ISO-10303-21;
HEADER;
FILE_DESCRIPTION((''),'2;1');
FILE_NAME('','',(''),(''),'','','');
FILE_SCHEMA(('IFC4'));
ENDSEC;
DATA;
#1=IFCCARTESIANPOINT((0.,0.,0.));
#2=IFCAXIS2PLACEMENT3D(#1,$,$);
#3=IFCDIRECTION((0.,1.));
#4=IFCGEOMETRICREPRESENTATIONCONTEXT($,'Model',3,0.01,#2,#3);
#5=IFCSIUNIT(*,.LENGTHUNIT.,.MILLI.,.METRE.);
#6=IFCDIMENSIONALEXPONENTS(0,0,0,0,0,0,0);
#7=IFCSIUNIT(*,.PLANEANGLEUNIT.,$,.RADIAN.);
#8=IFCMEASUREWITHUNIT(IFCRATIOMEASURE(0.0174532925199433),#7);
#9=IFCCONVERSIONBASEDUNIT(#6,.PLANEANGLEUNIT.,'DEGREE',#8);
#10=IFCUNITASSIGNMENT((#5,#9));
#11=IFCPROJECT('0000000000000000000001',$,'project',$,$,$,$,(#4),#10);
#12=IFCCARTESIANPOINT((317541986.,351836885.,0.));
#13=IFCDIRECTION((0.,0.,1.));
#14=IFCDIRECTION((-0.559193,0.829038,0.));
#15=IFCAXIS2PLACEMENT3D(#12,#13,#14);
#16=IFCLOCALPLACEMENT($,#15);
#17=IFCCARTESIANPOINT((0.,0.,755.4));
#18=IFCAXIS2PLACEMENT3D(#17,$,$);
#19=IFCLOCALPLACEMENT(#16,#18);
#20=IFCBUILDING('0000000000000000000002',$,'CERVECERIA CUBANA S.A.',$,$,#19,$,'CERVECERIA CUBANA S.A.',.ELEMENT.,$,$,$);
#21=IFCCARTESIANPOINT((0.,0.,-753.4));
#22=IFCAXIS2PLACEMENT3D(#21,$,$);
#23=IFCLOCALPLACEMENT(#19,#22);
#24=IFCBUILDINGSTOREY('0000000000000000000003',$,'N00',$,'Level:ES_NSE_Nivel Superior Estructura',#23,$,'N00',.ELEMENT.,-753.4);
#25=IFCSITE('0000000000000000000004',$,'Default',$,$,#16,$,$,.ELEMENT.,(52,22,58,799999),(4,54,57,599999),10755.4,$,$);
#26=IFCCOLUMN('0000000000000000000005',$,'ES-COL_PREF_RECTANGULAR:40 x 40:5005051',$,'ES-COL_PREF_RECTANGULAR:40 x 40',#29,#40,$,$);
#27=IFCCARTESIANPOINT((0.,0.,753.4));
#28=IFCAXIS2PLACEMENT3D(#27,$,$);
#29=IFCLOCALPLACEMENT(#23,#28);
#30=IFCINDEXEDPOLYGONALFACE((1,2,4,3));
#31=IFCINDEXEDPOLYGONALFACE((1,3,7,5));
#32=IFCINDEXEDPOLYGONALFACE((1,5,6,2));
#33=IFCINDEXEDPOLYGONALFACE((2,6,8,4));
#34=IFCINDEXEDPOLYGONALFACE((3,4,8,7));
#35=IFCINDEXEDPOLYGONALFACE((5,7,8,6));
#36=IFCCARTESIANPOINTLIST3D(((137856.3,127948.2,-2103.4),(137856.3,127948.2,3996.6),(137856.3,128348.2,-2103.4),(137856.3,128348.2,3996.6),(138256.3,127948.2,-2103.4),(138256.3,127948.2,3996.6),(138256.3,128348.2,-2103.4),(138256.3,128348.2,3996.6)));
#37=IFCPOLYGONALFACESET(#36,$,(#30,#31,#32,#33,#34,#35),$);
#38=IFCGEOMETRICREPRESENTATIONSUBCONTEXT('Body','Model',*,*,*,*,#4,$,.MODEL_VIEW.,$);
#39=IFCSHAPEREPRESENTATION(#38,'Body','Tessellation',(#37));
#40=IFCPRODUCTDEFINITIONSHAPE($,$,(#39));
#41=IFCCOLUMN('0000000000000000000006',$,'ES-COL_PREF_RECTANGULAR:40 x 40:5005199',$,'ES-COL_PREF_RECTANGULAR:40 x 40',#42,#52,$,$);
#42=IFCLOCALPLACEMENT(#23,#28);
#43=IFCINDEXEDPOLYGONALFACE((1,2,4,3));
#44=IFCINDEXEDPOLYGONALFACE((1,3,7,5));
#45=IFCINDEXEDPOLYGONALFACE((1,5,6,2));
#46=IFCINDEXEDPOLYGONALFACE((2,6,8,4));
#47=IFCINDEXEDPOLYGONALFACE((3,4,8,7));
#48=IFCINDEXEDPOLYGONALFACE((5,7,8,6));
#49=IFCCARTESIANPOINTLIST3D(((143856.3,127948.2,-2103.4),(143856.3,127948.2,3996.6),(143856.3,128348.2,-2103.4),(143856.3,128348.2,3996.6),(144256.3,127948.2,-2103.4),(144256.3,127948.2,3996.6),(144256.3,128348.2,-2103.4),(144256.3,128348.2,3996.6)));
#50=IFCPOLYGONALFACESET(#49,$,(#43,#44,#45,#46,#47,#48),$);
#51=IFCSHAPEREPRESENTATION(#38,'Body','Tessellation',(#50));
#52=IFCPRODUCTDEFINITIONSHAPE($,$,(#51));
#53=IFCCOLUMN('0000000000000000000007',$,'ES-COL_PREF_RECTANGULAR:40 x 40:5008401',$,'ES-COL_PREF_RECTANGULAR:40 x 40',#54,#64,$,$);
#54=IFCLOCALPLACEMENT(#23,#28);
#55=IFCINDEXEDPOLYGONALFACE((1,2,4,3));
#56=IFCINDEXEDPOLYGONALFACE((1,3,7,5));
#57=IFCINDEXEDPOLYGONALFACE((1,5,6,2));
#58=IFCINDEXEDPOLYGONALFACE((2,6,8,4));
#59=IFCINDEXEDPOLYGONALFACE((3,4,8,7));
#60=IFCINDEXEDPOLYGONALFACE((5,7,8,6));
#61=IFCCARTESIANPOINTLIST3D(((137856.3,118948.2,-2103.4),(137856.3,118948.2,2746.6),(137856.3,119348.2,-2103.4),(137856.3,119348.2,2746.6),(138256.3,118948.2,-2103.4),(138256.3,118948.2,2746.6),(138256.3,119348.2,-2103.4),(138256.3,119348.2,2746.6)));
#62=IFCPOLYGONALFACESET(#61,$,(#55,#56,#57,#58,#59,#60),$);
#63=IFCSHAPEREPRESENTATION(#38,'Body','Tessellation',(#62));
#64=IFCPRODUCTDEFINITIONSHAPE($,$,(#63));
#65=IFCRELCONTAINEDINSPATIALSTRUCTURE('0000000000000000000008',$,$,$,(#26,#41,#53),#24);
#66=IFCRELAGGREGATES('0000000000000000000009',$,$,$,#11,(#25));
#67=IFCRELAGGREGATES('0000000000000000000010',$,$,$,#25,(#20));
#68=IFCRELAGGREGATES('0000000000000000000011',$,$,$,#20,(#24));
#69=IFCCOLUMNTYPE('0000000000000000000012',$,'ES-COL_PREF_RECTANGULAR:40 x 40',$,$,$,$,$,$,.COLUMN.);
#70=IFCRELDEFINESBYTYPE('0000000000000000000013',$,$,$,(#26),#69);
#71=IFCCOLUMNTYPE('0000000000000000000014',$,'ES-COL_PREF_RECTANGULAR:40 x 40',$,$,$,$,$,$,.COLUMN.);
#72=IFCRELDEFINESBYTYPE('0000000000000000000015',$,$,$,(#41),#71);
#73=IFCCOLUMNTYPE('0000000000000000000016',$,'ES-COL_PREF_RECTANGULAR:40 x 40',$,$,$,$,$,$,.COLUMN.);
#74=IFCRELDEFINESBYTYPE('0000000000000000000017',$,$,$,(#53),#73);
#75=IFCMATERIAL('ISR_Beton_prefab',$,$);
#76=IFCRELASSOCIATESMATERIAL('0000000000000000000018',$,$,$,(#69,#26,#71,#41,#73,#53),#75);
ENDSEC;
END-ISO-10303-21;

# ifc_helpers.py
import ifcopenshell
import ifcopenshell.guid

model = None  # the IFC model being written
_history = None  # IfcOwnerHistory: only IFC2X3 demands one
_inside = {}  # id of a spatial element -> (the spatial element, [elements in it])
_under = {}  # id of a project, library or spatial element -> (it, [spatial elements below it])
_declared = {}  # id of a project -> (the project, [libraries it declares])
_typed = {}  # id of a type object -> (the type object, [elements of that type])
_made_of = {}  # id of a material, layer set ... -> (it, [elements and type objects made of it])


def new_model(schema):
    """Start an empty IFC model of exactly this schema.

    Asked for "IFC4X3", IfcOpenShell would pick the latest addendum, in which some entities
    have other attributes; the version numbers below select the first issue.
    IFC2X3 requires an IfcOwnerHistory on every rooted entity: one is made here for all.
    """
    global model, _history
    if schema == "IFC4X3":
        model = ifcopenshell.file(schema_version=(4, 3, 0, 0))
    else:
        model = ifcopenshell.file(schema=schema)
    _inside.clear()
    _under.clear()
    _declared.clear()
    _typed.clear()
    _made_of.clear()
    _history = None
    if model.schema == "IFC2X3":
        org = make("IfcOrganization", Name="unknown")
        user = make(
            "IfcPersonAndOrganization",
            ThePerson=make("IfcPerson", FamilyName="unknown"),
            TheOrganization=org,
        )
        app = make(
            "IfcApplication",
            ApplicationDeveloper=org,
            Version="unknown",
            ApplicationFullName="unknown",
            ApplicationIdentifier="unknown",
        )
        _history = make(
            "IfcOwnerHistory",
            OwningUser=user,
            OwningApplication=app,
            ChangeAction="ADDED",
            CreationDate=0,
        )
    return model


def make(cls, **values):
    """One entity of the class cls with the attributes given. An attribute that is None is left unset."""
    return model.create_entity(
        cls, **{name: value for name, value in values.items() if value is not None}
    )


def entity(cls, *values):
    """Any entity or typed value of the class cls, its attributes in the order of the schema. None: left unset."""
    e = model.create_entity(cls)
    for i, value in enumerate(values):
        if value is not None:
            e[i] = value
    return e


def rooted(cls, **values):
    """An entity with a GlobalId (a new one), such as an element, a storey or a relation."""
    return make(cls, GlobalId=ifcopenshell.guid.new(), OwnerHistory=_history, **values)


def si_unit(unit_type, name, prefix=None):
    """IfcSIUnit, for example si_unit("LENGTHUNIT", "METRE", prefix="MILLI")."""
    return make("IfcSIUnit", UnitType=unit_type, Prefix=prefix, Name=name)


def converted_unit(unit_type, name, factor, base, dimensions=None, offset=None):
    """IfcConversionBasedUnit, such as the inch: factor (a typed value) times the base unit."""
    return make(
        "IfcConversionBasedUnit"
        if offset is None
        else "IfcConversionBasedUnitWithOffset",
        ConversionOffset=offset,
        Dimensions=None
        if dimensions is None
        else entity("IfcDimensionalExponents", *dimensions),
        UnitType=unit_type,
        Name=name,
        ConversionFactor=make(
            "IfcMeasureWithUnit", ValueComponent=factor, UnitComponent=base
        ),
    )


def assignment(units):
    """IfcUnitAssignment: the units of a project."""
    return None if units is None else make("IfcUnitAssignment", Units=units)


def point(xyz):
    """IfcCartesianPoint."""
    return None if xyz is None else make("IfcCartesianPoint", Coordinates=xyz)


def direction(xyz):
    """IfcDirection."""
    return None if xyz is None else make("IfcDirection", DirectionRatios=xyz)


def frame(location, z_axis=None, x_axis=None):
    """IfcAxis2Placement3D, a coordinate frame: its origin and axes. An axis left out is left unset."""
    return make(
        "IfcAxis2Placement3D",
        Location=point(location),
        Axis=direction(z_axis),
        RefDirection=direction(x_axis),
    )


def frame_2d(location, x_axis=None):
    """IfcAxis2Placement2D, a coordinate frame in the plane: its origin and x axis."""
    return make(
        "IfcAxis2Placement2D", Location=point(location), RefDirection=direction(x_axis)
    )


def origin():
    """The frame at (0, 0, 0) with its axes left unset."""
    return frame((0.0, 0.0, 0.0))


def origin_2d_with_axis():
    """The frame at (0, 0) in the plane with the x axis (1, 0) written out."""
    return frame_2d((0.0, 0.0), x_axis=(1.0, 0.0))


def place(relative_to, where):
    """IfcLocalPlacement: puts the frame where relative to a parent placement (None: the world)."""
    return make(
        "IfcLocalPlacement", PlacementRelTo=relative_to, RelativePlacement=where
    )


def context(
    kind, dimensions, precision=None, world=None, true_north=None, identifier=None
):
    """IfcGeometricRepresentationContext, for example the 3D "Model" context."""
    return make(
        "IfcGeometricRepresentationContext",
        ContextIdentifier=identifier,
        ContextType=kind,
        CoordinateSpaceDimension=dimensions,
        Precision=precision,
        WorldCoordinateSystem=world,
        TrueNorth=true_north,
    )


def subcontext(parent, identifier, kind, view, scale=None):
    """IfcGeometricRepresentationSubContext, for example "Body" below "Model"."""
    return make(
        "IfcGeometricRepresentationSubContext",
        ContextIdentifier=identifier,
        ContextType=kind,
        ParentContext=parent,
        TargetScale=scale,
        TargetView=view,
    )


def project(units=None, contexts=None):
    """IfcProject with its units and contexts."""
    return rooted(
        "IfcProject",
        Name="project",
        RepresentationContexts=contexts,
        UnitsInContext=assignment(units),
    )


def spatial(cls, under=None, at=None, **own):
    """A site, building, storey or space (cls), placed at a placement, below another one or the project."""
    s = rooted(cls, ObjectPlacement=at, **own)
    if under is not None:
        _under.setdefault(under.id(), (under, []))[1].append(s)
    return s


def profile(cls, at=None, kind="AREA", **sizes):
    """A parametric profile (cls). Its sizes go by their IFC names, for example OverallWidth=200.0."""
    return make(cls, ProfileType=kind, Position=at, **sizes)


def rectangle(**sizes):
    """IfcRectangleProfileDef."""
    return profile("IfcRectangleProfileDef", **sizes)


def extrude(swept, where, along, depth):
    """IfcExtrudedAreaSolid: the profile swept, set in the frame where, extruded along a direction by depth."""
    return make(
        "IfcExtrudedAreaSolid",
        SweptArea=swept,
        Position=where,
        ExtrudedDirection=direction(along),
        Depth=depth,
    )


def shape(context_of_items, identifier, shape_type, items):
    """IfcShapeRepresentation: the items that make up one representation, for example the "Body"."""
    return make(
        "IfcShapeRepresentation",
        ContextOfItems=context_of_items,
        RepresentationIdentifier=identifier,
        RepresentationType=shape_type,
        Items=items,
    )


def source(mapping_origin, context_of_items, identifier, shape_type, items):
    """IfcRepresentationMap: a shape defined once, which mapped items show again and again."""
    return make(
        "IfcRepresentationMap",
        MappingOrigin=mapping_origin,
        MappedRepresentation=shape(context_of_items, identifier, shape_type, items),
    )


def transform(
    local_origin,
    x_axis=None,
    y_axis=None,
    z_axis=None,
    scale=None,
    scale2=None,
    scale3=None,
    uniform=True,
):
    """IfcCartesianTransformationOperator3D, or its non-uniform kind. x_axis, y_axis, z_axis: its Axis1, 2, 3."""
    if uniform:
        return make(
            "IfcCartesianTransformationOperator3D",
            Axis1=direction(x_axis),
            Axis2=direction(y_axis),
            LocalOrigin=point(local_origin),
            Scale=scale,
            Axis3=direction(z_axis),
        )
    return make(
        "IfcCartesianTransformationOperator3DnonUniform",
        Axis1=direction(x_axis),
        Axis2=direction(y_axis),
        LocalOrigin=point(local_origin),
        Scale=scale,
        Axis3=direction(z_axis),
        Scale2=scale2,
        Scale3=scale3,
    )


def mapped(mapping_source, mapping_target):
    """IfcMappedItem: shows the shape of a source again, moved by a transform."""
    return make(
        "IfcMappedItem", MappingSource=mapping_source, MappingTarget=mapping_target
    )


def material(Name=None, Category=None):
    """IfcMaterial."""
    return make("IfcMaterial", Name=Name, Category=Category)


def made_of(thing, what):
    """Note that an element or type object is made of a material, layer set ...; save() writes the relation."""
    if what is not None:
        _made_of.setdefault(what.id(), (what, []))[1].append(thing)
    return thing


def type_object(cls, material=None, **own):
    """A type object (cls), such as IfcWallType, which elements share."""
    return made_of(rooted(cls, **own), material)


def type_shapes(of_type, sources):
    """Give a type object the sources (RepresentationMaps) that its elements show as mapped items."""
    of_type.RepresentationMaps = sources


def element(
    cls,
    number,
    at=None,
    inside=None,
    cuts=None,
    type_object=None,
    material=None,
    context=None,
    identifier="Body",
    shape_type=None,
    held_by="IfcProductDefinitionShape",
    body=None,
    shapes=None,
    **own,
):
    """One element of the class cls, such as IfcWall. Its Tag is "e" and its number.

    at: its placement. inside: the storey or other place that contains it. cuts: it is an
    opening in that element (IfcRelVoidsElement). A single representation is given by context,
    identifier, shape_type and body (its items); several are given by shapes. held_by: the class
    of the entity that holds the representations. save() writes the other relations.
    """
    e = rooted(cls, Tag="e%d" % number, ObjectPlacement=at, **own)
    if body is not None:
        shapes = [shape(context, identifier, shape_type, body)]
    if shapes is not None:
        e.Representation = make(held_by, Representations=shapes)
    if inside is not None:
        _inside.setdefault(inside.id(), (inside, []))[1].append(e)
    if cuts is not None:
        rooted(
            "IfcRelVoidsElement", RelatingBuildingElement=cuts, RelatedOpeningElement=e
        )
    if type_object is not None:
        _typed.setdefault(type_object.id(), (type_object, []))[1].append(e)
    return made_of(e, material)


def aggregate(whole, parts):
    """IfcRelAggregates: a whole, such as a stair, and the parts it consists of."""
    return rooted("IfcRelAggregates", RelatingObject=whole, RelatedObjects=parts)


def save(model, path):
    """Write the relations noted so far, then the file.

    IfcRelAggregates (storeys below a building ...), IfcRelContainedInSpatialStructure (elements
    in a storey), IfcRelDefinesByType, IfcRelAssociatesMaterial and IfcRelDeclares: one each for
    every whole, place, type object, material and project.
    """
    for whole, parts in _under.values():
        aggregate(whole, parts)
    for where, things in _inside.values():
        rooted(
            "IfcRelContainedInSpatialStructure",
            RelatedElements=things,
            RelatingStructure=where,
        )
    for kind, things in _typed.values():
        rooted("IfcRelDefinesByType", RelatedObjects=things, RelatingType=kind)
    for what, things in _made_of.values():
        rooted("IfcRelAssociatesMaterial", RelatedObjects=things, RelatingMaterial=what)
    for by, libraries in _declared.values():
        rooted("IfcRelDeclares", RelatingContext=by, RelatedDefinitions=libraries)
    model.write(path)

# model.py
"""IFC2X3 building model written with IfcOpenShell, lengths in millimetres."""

from ifc_helpers import new_model, entity, si_unit, converted_unit, direction, frame, frame_2d, origin, origin_2d_with_axis, place, context, subcontext, project, spatial, rectangle, extrude, source, transform, mapped, material, type_object, type_shapes, element, save


model = new_model("IFC2X3")

# Units and contexts
model_context = context("Model", 3, precision=0.01, world=origin(), true_north=direction((0.0, 1.0)))
body_context = subcontext(model_context, "Body", "Model", "MODEL_VIEW")
ifc_project = project(units=[si_unit("LENGTHUNIT", "METRE", prefix="MILLI"), converted_unit("PLANEANGLEUNIT", "DEGREE", entity("IfcRatioMeasure", 0.0174532925199433), si_unit("PLANEANGLEUNIT", "RADIAN"), dimensions=[0, 0, 0, 0, 0, 0, 0])], contexts=[model_context])

# Site, building, storey
site_placement = place(None, frame((317541986.0, 351836885.0, 0.0), z_axis=(0.0, 0.0, 1.0), x_axis=(-0.559193, 0.829038, 0.0)))
site = spatial("IfcSite", under=ifc_project, at=site_placement, Name="Default", CompositionType="ELEMENT", RefLatitude=(52, 22, 58, 799999), RefLongitude=(4, 54, 57, 599999), RefElevation=10755.4)
building_placement = place(site_placement, frame((0.0, 0.0, 755.4)))
building = spatial("IfcBuilding", under=site, at=building_placement, Name="CERVECERIA CUBANA S.A.", LongName="CERVECERIA CUBANA S.A.", CompositionType="ELEMENT")
storey_placement = place(building_placement, frame((0.0, 0.0, -753.4)))
storey = spatial("IfcBuildingStorey", under=building, at=storey_placement, Name="N00", ObjectType="Level:ES_NSE_Nivel Superior Estructura", LongName="N00", CompositionType="ELEMENT", Elevation=-753.4)

# Columns
ifc_material_1 = material(Name="ISR_Beton_prefab")
column_type_1 = type_object("IfcColumnType", Name="ES-COL_PREF_RECTANGULAR:40 x 40", PredefinedType="COLUMN", material=ifc_material_1)
shared_shape_1 = source(origin(), body_context, "Body", "SweptSolid", [
    extrude(rectangle(XDim=400.0, YDim=400.0, at=origin_2d_with_axis()), frame((138056.3, 128148.2, -2103.4), z_axis=(0.0, 0.0, 1.0), x_axis=(0.0, -1.0, 0.0)), (0.0, 0.0, 1.0), 6100.0),
])
type_shapes(column_type_1, [shared_shape_1])
column_1_placement = place(storey_placement, frame((0.0, 0.0, 753.4)))
element("IfcColumn", 1, at=column_1_placement, inside=storey, type_object=column_type_1, material=ifc_material_1, Name="ES-COL_PREF_RECTANGULAR:40 x 40:5005051", ObjectType="ES-COL_PREF_RECTANGULAR:40 x 40", context=body_context, shape_type="MappedRepresentation", body=[
    mapped(shared_shape_1, transform((0.0, 0.0, 0.0), scale=1.0)),
])
column_type_2 = type_object("IfcColumnType", Name="ES-COL_PREF_RECTANGULAR:40 x 40", PredefinedType="COLUMN", material=ifc_material_1)
shared_shape_2 = source(origin(), body_context, "Body", "SweptSolid", [
    extrude(rectangle(XDim=400.0, YDim=400.0, at=origin_2d_with_axis()), frame((144056.3, 128148.2, -2103.4), z_axis=(0.0, 0.0, 1.0), x_axis=(0.0, -1.0, 0.0)), (0.0, 0.0, 1.0), 6100.0),
])
type_shapes(column_type_2, [shared_shape_2])
column_2_placement = place(storey_placement, frame((0.0, 0.0, 753.4)))
element("IfcColumn", 2, at=column_2_placement, inside=storey, type_object=column_type_2, material=ifc_material_1, Name="ES-COL_PREF_RECTANGULAR:40 x 40:5005199", ObjectType="ES-COL_PREF_RECTANGULAR:40 x 40", context=body_context, shape_type="MappedRepresentation", body=[
    mapped(shared_shape_2, transform((0.0, 0.0, 0.0), scale=1.0)),
])
column_type_3 = type_object("IfcColumnType", Name="ES-COL_PREF_RECTANGULAR:40 x 40", PredefinedType="COLUMN", material=ifc_material_1)
shared_shape_3 = source(origin(), body_context, "Body", "SweptSolid", [
    extrude(rectangle(XDim=400.0, YDim=400.0, at=frame_2d((0.0, 0.0), x_axis=(1.0, 0.0))), frame((138056.3, 119148.2, -2103.4), z_axis=(0.0, 0.0, 1.0), x_axis=(0.0, -1.0, 0.0)), (0.0, 0.0, 1.0), 4850.0),
])
type_shapes(column_type_3, [shared_shape_3])
column_3_placement = place(storey_placement, frame((0.0, 0.0, 753.4)))
element("IfcColumn", 3, at=column_3_placement, inside=storey, type_object=column_type_3, material=ifc_material_1, Name="ES-COL_PREF_RECTANGULAR:40 x 40:5008401", ObjectType="ES-COL_PREF_RECTANGULAR:40 x 40", context=body_context, shape_type="MappedRepresentation", body=[
    mapped(shared_shape_3, transform((0.0, 0.0, 0.0), scale=1.0)),
])

save(model, "model.ifc")
